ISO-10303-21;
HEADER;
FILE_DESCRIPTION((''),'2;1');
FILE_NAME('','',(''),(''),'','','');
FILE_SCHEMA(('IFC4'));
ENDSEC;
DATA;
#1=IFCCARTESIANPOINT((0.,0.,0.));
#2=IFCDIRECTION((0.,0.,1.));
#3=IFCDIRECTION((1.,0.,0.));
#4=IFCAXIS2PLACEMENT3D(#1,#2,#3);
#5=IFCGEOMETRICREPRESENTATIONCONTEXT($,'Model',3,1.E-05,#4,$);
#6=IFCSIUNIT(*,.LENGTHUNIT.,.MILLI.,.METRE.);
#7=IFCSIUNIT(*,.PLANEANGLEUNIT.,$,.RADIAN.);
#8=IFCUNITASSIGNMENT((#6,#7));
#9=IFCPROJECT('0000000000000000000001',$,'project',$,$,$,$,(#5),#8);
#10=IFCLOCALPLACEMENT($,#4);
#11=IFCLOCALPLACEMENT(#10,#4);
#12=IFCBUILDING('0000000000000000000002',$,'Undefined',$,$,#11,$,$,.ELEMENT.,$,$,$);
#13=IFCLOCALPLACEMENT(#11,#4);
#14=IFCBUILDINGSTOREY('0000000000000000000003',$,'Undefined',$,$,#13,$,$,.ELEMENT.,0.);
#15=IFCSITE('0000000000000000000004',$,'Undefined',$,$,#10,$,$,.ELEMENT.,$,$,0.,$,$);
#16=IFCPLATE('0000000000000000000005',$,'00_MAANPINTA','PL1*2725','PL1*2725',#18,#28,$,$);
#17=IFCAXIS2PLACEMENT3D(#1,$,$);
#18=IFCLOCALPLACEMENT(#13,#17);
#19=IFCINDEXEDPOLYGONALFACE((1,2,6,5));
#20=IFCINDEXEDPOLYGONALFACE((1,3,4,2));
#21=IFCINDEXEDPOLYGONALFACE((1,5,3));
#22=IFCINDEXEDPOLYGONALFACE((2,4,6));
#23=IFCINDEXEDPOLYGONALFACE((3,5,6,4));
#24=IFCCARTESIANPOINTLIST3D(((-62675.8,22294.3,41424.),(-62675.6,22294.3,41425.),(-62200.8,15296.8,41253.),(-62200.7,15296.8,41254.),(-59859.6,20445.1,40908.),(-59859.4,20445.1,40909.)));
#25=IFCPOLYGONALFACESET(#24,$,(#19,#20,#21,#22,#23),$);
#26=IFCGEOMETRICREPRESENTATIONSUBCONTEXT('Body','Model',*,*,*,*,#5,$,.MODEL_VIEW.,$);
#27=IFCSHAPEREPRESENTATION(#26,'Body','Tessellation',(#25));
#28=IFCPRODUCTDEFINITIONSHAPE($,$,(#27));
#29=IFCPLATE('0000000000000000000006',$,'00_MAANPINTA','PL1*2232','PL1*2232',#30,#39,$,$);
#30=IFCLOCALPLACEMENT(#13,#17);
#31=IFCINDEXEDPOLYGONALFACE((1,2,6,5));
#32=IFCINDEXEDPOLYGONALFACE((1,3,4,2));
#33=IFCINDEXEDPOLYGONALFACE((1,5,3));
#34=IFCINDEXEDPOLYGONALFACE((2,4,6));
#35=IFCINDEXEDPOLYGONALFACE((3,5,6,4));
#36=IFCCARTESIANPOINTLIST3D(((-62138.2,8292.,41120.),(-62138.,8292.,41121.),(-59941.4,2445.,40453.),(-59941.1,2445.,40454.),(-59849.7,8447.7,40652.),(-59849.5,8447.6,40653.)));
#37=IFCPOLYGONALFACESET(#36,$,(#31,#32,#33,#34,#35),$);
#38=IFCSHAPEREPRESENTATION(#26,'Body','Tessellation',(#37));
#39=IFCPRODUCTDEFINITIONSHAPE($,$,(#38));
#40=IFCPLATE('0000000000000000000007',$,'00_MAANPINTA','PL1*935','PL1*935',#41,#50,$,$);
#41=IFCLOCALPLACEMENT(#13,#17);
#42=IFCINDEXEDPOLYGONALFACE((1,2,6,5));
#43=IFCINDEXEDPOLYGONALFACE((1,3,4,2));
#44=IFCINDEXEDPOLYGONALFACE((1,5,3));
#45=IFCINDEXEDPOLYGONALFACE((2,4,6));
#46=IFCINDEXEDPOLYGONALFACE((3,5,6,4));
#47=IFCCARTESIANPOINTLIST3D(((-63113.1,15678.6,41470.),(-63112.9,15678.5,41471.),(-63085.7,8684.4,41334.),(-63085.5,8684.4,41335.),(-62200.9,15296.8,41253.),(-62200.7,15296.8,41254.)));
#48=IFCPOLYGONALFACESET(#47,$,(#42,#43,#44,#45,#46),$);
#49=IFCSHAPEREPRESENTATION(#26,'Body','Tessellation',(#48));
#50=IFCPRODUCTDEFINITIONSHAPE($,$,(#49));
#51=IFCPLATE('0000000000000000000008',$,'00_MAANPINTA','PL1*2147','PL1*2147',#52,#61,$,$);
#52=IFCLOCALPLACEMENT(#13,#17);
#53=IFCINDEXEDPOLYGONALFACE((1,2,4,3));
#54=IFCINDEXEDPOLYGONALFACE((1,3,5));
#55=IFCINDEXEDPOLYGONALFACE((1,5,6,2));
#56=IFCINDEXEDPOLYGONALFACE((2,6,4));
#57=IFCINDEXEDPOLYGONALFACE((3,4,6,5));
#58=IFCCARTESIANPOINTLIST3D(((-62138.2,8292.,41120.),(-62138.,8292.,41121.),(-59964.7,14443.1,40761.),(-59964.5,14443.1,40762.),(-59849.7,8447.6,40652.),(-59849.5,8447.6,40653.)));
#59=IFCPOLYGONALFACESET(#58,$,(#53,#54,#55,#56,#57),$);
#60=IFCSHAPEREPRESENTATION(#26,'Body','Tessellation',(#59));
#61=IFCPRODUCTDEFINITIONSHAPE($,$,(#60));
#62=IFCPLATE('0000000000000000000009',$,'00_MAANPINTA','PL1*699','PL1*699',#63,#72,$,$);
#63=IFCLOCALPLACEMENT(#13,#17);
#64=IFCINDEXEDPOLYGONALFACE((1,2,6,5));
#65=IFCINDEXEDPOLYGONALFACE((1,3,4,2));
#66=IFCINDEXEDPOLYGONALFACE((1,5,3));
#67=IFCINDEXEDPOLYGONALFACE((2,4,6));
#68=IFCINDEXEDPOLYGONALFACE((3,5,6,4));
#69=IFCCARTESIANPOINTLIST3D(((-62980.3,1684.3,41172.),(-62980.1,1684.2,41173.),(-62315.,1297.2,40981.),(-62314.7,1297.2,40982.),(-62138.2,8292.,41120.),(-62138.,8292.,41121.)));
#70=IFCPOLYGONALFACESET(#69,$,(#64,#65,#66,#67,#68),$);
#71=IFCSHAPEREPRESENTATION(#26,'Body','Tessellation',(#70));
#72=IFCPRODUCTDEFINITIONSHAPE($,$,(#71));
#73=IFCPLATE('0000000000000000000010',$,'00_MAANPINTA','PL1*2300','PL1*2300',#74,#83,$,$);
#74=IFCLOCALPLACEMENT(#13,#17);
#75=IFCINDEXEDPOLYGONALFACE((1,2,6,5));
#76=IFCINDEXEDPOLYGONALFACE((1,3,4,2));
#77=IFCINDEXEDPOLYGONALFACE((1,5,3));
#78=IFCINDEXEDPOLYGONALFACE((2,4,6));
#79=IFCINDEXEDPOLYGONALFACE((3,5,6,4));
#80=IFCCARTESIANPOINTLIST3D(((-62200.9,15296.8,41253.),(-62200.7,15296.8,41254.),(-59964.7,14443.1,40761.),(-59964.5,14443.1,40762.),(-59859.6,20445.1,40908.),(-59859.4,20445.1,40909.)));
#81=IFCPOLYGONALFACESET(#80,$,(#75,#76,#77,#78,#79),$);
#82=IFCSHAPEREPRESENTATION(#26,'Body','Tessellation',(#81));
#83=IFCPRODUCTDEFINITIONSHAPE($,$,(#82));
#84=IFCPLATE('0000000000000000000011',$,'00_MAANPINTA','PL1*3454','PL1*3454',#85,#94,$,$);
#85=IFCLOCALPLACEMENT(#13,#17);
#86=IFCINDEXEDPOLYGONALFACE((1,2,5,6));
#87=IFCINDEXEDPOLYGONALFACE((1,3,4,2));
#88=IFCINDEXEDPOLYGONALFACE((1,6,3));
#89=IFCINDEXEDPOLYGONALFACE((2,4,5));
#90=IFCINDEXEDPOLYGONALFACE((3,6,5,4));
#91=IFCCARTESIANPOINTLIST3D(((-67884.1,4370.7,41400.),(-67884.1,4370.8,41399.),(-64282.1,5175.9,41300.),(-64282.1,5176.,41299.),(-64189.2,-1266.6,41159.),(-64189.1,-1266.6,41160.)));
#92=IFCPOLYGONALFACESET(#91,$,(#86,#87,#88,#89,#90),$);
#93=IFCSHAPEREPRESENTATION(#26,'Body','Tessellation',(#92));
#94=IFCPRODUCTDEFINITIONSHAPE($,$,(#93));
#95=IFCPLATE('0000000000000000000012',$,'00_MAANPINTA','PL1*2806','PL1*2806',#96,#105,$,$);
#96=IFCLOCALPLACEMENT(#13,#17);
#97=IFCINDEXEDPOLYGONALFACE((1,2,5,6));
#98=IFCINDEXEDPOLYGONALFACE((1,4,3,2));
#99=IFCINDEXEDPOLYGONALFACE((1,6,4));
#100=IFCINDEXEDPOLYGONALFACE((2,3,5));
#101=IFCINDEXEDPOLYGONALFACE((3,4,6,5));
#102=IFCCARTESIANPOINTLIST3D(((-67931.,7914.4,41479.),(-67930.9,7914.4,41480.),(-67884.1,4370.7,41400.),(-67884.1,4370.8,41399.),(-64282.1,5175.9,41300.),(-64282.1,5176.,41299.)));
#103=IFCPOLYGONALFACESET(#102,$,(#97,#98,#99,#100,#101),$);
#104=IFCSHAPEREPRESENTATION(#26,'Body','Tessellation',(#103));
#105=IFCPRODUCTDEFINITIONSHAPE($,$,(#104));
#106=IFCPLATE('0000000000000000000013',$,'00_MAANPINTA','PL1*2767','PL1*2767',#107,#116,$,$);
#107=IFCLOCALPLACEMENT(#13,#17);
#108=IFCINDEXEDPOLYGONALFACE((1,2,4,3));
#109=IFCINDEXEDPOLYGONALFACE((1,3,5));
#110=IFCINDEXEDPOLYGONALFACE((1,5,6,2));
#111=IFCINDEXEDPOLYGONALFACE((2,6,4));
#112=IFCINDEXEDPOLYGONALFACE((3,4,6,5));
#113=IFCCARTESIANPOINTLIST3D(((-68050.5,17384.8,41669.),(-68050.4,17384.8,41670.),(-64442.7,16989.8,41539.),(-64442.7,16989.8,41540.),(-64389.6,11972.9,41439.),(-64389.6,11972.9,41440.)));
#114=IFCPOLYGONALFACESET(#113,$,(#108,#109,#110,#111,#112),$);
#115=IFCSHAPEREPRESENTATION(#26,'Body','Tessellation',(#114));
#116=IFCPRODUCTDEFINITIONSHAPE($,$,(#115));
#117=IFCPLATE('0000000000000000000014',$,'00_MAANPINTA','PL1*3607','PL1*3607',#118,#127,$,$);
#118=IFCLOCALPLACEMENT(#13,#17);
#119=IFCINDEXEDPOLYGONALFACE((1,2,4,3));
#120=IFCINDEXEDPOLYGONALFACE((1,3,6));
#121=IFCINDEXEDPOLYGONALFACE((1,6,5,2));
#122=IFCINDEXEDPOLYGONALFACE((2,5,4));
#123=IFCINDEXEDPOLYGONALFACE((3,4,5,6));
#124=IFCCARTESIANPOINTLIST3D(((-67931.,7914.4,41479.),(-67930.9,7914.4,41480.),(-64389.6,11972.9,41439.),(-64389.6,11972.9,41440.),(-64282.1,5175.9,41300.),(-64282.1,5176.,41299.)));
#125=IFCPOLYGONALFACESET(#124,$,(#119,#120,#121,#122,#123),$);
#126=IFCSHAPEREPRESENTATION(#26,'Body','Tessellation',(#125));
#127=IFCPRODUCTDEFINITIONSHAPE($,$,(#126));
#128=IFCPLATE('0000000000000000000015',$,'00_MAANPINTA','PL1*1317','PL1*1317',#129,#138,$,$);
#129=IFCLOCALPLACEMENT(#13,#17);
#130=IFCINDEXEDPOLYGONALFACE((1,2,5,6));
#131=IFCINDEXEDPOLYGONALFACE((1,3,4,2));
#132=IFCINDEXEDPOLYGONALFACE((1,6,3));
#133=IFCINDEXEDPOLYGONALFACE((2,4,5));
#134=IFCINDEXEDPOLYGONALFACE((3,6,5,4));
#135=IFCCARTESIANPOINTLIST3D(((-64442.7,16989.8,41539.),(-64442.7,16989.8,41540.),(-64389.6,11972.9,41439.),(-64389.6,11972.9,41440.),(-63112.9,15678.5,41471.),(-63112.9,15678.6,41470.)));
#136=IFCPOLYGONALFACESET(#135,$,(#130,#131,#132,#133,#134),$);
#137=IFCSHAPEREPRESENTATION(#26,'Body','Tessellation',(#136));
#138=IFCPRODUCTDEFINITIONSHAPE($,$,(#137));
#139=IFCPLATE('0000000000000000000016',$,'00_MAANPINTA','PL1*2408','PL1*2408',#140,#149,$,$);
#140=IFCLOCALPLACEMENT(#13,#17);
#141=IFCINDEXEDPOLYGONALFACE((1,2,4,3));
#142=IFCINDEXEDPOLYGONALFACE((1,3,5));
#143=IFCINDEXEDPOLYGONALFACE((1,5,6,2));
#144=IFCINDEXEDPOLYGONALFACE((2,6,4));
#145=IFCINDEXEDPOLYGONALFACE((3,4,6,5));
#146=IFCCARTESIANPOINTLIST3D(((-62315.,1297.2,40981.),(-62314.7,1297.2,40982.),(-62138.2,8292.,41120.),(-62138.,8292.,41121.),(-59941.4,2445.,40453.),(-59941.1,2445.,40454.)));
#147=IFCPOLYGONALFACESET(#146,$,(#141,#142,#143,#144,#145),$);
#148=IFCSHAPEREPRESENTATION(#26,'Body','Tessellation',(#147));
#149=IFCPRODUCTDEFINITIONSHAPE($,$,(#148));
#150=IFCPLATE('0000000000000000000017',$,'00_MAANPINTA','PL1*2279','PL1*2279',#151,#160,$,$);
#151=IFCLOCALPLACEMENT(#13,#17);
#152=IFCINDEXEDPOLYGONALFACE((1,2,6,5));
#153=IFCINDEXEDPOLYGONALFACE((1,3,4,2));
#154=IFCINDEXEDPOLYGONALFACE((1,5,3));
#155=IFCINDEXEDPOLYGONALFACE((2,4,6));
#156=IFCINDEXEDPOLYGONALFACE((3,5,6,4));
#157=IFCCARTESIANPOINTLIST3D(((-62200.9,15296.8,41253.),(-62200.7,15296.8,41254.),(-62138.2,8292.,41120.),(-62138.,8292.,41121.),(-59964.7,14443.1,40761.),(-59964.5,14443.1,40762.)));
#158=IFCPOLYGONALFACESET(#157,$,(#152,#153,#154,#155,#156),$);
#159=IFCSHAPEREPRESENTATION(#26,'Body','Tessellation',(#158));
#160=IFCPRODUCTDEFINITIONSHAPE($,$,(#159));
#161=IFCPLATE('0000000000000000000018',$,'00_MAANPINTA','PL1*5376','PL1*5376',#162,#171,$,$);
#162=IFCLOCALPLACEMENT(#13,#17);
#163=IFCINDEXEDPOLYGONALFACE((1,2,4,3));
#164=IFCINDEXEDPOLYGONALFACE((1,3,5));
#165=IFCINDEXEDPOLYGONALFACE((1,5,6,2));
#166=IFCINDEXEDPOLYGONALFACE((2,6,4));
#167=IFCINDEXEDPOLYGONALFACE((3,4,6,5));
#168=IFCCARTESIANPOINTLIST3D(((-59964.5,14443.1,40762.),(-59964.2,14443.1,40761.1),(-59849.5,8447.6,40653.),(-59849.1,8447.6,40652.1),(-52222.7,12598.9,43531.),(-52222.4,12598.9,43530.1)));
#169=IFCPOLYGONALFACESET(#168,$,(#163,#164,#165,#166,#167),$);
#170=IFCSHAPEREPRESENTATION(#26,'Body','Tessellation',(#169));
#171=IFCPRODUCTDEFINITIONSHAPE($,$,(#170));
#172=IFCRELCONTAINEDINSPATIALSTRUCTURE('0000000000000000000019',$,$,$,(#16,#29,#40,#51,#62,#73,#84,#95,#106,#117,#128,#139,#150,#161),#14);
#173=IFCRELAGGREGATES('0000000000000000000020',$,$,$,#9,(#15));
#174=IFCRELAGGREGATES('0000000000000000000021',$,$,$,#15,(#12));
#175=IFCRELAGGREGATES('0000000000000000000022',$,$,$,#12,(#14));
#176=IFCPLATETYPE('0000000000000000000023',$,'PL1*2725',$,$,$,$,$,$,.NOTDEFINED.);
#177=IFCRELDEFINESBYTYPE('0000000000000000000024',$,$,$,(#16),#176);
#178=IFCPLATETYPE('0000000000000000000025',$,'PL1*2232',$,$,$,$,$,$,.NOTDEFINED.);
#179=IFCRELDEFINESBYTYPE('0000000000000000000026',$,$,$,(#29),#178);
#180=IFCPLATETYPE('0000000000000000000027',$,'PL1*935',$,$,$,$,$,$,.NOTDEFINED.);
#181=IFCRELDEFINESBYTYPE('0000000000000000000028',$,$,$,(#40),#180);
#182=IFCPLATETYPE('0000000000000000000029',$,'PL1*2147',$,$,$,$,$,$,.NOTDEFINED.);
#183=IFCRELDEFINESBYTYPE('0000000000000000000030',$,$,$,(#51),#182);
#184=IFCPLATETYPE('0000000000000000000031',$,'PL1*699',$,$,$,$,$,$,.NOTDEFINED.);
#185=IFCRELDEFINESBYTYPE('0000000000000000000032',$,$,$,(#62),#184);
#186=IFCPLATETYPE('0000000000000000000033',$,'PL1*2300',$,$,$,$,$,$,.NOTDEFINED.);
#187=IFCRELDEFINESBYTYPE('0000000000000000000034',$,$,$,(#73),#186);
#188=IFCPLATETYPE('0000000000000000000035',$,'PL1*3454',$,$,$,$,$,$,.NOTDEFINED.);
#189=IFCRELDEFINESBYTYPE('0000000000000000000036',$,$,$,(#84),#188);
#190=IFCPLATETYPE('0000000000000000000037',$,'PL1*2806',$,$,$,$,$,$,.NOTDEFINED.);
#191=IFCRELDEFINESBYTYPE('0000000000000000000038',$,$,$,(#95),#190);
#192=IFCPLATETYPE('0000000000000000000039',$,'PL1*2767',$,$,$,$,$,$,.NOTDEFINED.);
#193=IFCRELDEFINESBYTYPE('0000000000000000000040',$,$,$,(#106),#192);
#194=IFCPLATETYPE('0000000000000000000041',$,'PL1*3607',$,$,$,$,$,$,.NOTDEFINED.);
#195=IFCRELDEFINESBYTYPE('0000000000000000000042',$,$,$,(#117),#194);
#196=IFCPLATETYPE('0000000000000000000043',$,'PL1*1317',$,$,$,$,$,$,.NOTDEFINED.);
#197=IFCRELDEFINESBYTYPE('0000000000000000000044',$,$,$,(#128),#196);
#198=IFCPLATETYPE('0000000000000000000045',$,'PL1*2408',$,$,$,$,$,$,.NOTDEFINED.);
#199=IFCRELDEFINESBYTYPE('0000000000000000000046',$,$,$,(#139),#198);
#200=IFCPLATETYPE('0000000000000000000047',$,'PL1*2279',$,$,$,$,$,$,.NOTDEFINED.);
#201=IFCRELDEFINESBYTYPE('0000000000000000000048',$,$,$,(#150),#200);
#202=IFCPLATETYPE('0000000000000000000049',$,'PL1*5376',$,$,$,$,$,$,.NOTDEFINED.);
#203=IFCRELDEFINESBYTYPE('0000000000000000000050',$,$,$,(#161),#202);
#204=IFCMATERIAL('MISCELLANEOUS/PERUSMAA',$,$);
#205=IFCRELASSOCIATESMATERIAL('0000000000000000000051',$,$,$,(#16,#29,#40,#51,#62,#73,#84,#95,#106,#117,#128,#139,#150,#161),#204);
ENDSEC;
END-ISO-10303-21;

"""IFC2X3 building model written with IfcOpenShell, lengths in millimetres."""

from ifc_helpers import new_model, si_unit, frame, origin_with_axes, place, context, subcontext, project, spatial, polyline, outline, extrude, material, type_object, element, save


model = new_model("IFC2X3")

# Units and contexts
model_context = context("Model", 3, precision=1e-05, world=origin_with_axes())
body_context = subcontext(model_context, "Body", "Model", "MODEL_VIEW")
ifc_project = project(units=[si_unit("LENGTHUNIT", "METRE", prefix="MILLI"), si_unit("PLANEANGLEUNIT", "RADIAN")], contexts=[model_context])

# Site, building, storey
site_placement = place(None, origin_with_axes())
site = spatial("IfcSite", under=ifc_project, at=site_placement, Name="Undefined", CompositionType="ELEMENT", RefElevation=0.0)
building_placement = place(site_placement, origin_with_axes())
building = spatial("IfcBuilding", under=site, at=building_placement, Name="Undefined", CompositionType="ELEMENT")
storey_placement = place(building_placement, origin_with_axes())
storey = spatial("IfcBuildingStorey", under=building, at=storey_placement, Name="Undefined", CompositionType="ELEMENT", Elevation=0.0)

# Plates
ifc_material = material(Name="MISCELLANEOUS/PERUSMAA")
plate_type_1 = type_object("IfcPlateType", Name="PL1*2725", PredefinedType="NOTDEFINED")
plate_1_placement = place(storey_placement, frame((-59859.5, 20445.1, 40908.5), z_axis=(-0.172346, 0.012372, -0.984959), x_axis=(-0.413198, -0.908604, 0.060888)))
element("IfcPlate", 1, at=plate_1_placement, inside=storey, type_object=plate_type_1, material=ifc_material, Name="00_MAANPINTA", Description="PL1*2725", ObjectType="PL1*2725", context=body_context, shape_type="SweptSolid", body=[
    extrude(outline(polyline([(0.0, 0.0), (5666.2, 0.0), (-485.1, 3373.6), (0.0, 0.0)])), frame((0.0, 0.0, -0.5), z_axis=(0.0, 0.0, 1.0), x_axis=(1.0, 0.0, 0.0)), (0.0, 0.0, 1.0), 1.0),
])
plate_type_2 = type_object("IfcPlateType", Name="PL1*2232", PredefinedType="NOTDEFINED")
plate_2_placement = place(storey_placement, frame((-59849.6, 8447.6, 40652.5), z_axis=(-0.202547, 0.035537, -0.978627), x_axis=(-0.015265, -0.999334, -0.03313)))
element("IfcPlate", 2, at=plate_2_placement, inside=storey, type_object=plate_type_2, material=ifc_material, Name="00_MAANPINTA", Description="PL1*2232", ObjectType="PL1*2232", context=body_context, shape_type="SweptSolid", body=[
    extrude(outline(polyline([(0.0, 0.0), (6006.7, 0.0), (175.0, 2334.5), (0.0, 0.0)])), frame((0.0, 0.0, -0.5), z_axis=(0.0, 0.0, 1.0), x_axis=(1.0, 0.0, 0.0)), (0.0, 0.0, 1.0), 1.0),
])
plate_type_3 = type_object("IfcPlateType", Name="PL1*935", PredefinedType="NOTDEFINED")
plate_3_placement = place(storey_placement, frame((-63085.6, 8684.4, 41334.5), z_axis=(-0.224216, 0.018068, -0.974372), x_axis=(-0.003915, 0.999803, 0.019441)))
element("IfcPlate", 3, at=plate_3_placement, inside=storey, type_object=plate_type_3, material=ifc_material, Name="00_MAANPINTA", Description="PL1*935", ObjectType="PL1*935", context=body_context, shape_type="SweptSolid", body=[
    extrude(outline(polyline([(0.0, 0.0), (6995.6, 0.0), (6606.1, 934.5), (0.0, 0.0)])), frame((0.0, 0.0, -0.5), z_axis=(0.0, 0.0, 1.0), x_axis=(1.0, 0.0, 0.0)), (0.0, 0.0, 1.0), 1.0),
])
plate_type_4 = type_object("IfcPlateType", Name="PL1*2147", PredefinedType="NOTDEFINED")
plate_4_placement = place(storey_placement, frame((-59964.6, 14443.1, 40761.5), z_axis=(-0.201245, 0.013945, -0.979442), x_axis=(0.019182, -0.999651, -0.018174)))
element("IfcPlate", 4, at=plate_4_placement, inside=storey, type_object=plate_type_4, material=ifc_material, Name="00_MAANPINTA", Description="PL1*2147", ObjectType="PL1*2147", context=body_context, shape_type="SweptSolid", body=[
    extrude(outline(polyline([(0.0, 0.0), (5997.5, 0.0), (6100.7, 2338.8), (0.0, 0.0)])), frame((0.0, 0.0, -0.5), z_axis=(0.0, 0.0, 1.0), x_axis=(1.0, 0.0, 0.0)), (0.0, 0.0, 1.0), 1.0),
])
plate_type_5 = type_object("IfcPlateType", Name="PL1*699", PredefinedType="NOTDEFINED")
plate_5_placement = place(storey_placement, frame((-62138.1, 8292.0, 41120.5), z_axis=(-0.261956, 0.025792, -0.964735), x_axis=(-0.025263, -0.999484, -0.019862)))
element("IfcPlate", 5, at=plate_5_placement, inside=storey, type_object=plate_type_5, material=ifc_material, Name="00_MAANPINTA", Description="PL1*699", ObjectType="PL1*699", context=body_context, shape_type="SweptSolid", body=[
    extrude(outline(polyline([(0.0, 0.0), (6998.4, 0.0), (6624.6, 699.4), (0.0, 0.0)])), frame((0.0, 0.0, -0.5), z_axis=(0.0, 0.0, 1.0), x_axis=(1.0, 0.0, 0.0)), (0.0, 0.0, 1.0), 1.0),
])
plate_type_6 = type_object("IfcPlateType", Name="PL1*2300", PredefinedType="NOTDEFINED")
plate_6_placement = place(storey_placement, frame((-59859.5, 20445.1, 40908.5), z_axis=(-0.204756, 0.027549, -0.978425), x_axis=(-0.017502, -0.999547, -0.024481)))
element("IfcPlate", 6, at=plate_6_placement, inside=storey, type_object=plate_type_6, material=ifc_material, Name="00_MAANPINTA", Description="PL1*2300", ObjectType="PL1*2300", context=body_context, shape_type="SweptSolid", body=[
    extrude(outline(polyline([(0.0, 0.0), (6004.7, 0.0), (5178.5, 2299.7), (0.0, 0.0)])), frame((0.0, 0.0, -0.5), z_axis=(0.0, 0.0, 1.0), x_axis=(1.0, 0.0, 0.0)), (0.0, 0.0, 1.0), 1.0),
])
plate_type_7 = type_object("IfcPlateType", Name="PL1*3454", PredefinedType="NOTDEFINED")
plate_7_placement = place(storey_placement, frame((-64282.1, 5175.9, 41299.5), z_axis=(-0.032491, 0.021245, -0.999246), x_axis=(0.014422, -0.99966, -0.021723)))
element("IfcPlate", 7, at=plate_7_placement, inside=storey, type_object=plate_type_7, material=ifc_material, Name="00_MAANPINTA", Description="PL1*3454", ObjectType="PL1*3454", context=body_context, shape_type="SweptSolid", body=[
    extrude(outline(polyline([(0.0, 0.0), (6444.8, 0.0), (750.8, 3615.1), (0.0, 0.0)])), frame((0.0, 0.0, -0.5), z_axis=(0.0, 0.0, 1.0), x_axis=(1.0, 0.0, 0.0)), (0.0, 0.0, 1.0), 1.0),
])
plate_type_8 = type_object("IfcPlateType", Name="PL1*2806", PredefinedType="NOTDEFINED")
plate_8_placement = place(storey_placement, frame((-67931.0, 7914.4, 41479.5), z_axis=(-0.032687, 0.022126, -0.999221), x_axis=(0.799188, -0.599786, -0.039424)))
element("IfcPlate", 8, at=plate_8_placement, inside=storey, type_object=plate_type_8, material=ifc_material, Name="00_MAANPINTA", Description="PL1*2806", ObjectType="PL1*2806", context=body_context, shape_type="SweptSolid", body=[
    extrude(outline(polyline([(0.0, 0.0), (4565.7, 0.0), (2166.0, 2806.1), (0.0, 0.0)])), frame((0.0, 0.0, -0.5), z_axis=(0.0, 0.0, 1.0), x_axis=(1.0, 0.0, 0.0)), (0.0, 0.0, 1.0), 1.0),
])
plate_type_9 = type_object("IfcPlateType", Name="PL1*2767", PredefinedType="NOTDEFINED")
plate_9_placement = place(storey_placement, frame((-68050.5, 17384.8, 41669.5), z_axis=(-0.033865, 0.019559, -0.999235), x_axis=(0.993424, -0.108751, -0.035796)))
element("IfcPlate", 9, at=plate_9_placement, inside=storey, type_object=plate_type_9, material=ifc_material, Name="00_MAANPINTA", Description="PL1*2767", ObjectType="PL1*2767", context=body_context, shape_type="SweptSolid", body=[
    extrude(outline(polyline([(0.0, 0.0), (3631.7, 0.0), (4233.6, 4982.0), (0.0, 0.0)])), frame((0.0, 0.0, -0.5), z_axis=(0.0, 0.0, 1.0), x_axis=(1.0, 0.0, 0.0)), (0.0, 0.0, 1.0), 1.0),
])
plate_type_10 = type_object("IfcPlateType", Name="PL1*3607", PredefinedType="NOTDEFINED")
plate_10_placement = place(storey_placement, frame((-64389.6, 11972.9, 41439.5), z_axis=(-0.034252, 0.02004, -0.999212), x_axis=(0.015808, -0.999663, -0.020591)))
element("IfcPlate", 10, at=plate_10_placement, inside=storey, type_object=plate_type_10, material=ifc_material, Name="00_MAANPINTA", Description="PL1*3607", ObjectType="PL1*3607", context=body_context, shape_type="SweptSolid", body=[
    extrude(outline(polyline([(0.0, 0.0), (6799.2, 0.0), (4000.3, 3607.2), (0.0, 0.0)])), frame((0.0, 0.0, -0.5), z_axis=(0.0, 0.0, 1.0), x_axis=(1.0, 0.0, 0.0)), (0.0, 0.0, 1.0), 1.0),
])
plate_type_11 = type_object("IfcPlateType", Name="PL1*1317", PredefinedType="NOTDEFINED")
plate_11_placement = place(storey_placement, frame((-64442.7, 16989.8, 41539.5), z_axis=(-0.03255, 0.019574, -0.999278), x_axis=(0.71155, -0.701665, -0.036921)))
element("IfcPlate", 11, at=plate_11_placement, inside=storey, type_object=plate_type_11, material=ifc_material, Name="00_MAANPINTA", Description="PL1*1317", ObjectType="PL1*1317", context=body_context, shape_type="SweptSolid", body=[
    extrude(outline(polyline([(0.0, 0.0), (1868.8, 0.0), (3561.7, 3535.1), (0.0, 0.0)])), frame((0.0, 0.0, -0.5), z_axis=(0.0, 0.0, 1.0), x_axis=(1.0, 0.0, 0.0)), (0.0, 0.0, 1.0), 1.0),
])
plate_type_12 = type_object("IfcPlateType", Name="PL1*2408", PredefinedType="NOTDEFINED")
plate_12_placement = place(storey_placement, frame((-62138.1, 8292.0, 41120.5), z_axis=(-0.228629, 0.025118, -0.97319), x_axis=(0.34972, -0.930818, -0.106183)))
element("IfcPlate", 12, at=plate_12_placement, inside=storey, type_object=plate_type_12, material=ifc_material, Name="00_MAANPINTA", Description="PL1*2408", ObjectType="PL1*2408", context=body_context, shape_type="SweptSolid", body=[
    extrude(outline(polyline([(0.0, 0.0), (6281.6, 0.0), (6463.8, 2682.7), (0.0, 0.0)])), frame((0.0, 0.0, -0.5), z_axis=(0.0, 0.0, 1.0), x_axis=(1.0, 0.0, 0.0)), (0.0, 0.0, 1.0), 1.0),
])
plate_type_13 = type_object("IfcPlateType", Name="PL1*2279", PredefinedType="NOTDEFINED")
plate_13_placement = place(storey_placement, frame((-59964.6, 14443.1, 40761.5), z_axis=(-0.208767, 0.016697, -0.977823), x_axis=(-0.332655, -0.941447, 0.054946)))
element("IfcPlate", 13, at=plate_13_placement, inside=storey, type_object=plate_type_13, material=ifc_material, Name="00_MAANPINTA", Description="PL1*2279", ObjectType="PL1*2279", context=body_context, shape_type="SweptSolid", body=[
    extrude(outline(polyline([(0.0, 0.0), (6533.6, 0.0), (-32.8, 2443.4), (0.0, 0.0)])), frame((0.0, 0.0, -0.5), z_axis=(0.0, 0.0, 1.0), x_axis=(1.0, 0.0, 0.0)), (0.0, 0.0, 1.0), 1.0),
])
plate_type_14 = type_object("IfcPlateType", Name="PL1*5376", PredefinedType="NOTDEFINED")
plate_14_placement = place(storey_placement, frame((-59849.3, 8447.6, 40652.5), z_axis=(0.34167, 0.023637, -0.939523), x_axis=(-0.019182, 0.999651, 0.018174)))
element("IfcPlate", 14, at=plate_14_placement, inside=storey, type_object=plate_type_14, material=ifc_material, Name="00_MAANPINTA", Description="PL1*5376", ObjectType="PL1*5376", context=body_context, shape_type="SweptSolid", body=[
    extrude(outline(polyline([(0.0, 0.0), (5997.5, 0.0), (4055.9, 8199.6), (0.0, 0.0)])), frame((0.0, 0.0, -0.5), z_axis=(0.0, 0.0, 1.0), x_axis=(1.0, 0.0, 0.0)), (0.0, 0.0, 1.0), 1.0),
])

save(model, "model.ifc")
